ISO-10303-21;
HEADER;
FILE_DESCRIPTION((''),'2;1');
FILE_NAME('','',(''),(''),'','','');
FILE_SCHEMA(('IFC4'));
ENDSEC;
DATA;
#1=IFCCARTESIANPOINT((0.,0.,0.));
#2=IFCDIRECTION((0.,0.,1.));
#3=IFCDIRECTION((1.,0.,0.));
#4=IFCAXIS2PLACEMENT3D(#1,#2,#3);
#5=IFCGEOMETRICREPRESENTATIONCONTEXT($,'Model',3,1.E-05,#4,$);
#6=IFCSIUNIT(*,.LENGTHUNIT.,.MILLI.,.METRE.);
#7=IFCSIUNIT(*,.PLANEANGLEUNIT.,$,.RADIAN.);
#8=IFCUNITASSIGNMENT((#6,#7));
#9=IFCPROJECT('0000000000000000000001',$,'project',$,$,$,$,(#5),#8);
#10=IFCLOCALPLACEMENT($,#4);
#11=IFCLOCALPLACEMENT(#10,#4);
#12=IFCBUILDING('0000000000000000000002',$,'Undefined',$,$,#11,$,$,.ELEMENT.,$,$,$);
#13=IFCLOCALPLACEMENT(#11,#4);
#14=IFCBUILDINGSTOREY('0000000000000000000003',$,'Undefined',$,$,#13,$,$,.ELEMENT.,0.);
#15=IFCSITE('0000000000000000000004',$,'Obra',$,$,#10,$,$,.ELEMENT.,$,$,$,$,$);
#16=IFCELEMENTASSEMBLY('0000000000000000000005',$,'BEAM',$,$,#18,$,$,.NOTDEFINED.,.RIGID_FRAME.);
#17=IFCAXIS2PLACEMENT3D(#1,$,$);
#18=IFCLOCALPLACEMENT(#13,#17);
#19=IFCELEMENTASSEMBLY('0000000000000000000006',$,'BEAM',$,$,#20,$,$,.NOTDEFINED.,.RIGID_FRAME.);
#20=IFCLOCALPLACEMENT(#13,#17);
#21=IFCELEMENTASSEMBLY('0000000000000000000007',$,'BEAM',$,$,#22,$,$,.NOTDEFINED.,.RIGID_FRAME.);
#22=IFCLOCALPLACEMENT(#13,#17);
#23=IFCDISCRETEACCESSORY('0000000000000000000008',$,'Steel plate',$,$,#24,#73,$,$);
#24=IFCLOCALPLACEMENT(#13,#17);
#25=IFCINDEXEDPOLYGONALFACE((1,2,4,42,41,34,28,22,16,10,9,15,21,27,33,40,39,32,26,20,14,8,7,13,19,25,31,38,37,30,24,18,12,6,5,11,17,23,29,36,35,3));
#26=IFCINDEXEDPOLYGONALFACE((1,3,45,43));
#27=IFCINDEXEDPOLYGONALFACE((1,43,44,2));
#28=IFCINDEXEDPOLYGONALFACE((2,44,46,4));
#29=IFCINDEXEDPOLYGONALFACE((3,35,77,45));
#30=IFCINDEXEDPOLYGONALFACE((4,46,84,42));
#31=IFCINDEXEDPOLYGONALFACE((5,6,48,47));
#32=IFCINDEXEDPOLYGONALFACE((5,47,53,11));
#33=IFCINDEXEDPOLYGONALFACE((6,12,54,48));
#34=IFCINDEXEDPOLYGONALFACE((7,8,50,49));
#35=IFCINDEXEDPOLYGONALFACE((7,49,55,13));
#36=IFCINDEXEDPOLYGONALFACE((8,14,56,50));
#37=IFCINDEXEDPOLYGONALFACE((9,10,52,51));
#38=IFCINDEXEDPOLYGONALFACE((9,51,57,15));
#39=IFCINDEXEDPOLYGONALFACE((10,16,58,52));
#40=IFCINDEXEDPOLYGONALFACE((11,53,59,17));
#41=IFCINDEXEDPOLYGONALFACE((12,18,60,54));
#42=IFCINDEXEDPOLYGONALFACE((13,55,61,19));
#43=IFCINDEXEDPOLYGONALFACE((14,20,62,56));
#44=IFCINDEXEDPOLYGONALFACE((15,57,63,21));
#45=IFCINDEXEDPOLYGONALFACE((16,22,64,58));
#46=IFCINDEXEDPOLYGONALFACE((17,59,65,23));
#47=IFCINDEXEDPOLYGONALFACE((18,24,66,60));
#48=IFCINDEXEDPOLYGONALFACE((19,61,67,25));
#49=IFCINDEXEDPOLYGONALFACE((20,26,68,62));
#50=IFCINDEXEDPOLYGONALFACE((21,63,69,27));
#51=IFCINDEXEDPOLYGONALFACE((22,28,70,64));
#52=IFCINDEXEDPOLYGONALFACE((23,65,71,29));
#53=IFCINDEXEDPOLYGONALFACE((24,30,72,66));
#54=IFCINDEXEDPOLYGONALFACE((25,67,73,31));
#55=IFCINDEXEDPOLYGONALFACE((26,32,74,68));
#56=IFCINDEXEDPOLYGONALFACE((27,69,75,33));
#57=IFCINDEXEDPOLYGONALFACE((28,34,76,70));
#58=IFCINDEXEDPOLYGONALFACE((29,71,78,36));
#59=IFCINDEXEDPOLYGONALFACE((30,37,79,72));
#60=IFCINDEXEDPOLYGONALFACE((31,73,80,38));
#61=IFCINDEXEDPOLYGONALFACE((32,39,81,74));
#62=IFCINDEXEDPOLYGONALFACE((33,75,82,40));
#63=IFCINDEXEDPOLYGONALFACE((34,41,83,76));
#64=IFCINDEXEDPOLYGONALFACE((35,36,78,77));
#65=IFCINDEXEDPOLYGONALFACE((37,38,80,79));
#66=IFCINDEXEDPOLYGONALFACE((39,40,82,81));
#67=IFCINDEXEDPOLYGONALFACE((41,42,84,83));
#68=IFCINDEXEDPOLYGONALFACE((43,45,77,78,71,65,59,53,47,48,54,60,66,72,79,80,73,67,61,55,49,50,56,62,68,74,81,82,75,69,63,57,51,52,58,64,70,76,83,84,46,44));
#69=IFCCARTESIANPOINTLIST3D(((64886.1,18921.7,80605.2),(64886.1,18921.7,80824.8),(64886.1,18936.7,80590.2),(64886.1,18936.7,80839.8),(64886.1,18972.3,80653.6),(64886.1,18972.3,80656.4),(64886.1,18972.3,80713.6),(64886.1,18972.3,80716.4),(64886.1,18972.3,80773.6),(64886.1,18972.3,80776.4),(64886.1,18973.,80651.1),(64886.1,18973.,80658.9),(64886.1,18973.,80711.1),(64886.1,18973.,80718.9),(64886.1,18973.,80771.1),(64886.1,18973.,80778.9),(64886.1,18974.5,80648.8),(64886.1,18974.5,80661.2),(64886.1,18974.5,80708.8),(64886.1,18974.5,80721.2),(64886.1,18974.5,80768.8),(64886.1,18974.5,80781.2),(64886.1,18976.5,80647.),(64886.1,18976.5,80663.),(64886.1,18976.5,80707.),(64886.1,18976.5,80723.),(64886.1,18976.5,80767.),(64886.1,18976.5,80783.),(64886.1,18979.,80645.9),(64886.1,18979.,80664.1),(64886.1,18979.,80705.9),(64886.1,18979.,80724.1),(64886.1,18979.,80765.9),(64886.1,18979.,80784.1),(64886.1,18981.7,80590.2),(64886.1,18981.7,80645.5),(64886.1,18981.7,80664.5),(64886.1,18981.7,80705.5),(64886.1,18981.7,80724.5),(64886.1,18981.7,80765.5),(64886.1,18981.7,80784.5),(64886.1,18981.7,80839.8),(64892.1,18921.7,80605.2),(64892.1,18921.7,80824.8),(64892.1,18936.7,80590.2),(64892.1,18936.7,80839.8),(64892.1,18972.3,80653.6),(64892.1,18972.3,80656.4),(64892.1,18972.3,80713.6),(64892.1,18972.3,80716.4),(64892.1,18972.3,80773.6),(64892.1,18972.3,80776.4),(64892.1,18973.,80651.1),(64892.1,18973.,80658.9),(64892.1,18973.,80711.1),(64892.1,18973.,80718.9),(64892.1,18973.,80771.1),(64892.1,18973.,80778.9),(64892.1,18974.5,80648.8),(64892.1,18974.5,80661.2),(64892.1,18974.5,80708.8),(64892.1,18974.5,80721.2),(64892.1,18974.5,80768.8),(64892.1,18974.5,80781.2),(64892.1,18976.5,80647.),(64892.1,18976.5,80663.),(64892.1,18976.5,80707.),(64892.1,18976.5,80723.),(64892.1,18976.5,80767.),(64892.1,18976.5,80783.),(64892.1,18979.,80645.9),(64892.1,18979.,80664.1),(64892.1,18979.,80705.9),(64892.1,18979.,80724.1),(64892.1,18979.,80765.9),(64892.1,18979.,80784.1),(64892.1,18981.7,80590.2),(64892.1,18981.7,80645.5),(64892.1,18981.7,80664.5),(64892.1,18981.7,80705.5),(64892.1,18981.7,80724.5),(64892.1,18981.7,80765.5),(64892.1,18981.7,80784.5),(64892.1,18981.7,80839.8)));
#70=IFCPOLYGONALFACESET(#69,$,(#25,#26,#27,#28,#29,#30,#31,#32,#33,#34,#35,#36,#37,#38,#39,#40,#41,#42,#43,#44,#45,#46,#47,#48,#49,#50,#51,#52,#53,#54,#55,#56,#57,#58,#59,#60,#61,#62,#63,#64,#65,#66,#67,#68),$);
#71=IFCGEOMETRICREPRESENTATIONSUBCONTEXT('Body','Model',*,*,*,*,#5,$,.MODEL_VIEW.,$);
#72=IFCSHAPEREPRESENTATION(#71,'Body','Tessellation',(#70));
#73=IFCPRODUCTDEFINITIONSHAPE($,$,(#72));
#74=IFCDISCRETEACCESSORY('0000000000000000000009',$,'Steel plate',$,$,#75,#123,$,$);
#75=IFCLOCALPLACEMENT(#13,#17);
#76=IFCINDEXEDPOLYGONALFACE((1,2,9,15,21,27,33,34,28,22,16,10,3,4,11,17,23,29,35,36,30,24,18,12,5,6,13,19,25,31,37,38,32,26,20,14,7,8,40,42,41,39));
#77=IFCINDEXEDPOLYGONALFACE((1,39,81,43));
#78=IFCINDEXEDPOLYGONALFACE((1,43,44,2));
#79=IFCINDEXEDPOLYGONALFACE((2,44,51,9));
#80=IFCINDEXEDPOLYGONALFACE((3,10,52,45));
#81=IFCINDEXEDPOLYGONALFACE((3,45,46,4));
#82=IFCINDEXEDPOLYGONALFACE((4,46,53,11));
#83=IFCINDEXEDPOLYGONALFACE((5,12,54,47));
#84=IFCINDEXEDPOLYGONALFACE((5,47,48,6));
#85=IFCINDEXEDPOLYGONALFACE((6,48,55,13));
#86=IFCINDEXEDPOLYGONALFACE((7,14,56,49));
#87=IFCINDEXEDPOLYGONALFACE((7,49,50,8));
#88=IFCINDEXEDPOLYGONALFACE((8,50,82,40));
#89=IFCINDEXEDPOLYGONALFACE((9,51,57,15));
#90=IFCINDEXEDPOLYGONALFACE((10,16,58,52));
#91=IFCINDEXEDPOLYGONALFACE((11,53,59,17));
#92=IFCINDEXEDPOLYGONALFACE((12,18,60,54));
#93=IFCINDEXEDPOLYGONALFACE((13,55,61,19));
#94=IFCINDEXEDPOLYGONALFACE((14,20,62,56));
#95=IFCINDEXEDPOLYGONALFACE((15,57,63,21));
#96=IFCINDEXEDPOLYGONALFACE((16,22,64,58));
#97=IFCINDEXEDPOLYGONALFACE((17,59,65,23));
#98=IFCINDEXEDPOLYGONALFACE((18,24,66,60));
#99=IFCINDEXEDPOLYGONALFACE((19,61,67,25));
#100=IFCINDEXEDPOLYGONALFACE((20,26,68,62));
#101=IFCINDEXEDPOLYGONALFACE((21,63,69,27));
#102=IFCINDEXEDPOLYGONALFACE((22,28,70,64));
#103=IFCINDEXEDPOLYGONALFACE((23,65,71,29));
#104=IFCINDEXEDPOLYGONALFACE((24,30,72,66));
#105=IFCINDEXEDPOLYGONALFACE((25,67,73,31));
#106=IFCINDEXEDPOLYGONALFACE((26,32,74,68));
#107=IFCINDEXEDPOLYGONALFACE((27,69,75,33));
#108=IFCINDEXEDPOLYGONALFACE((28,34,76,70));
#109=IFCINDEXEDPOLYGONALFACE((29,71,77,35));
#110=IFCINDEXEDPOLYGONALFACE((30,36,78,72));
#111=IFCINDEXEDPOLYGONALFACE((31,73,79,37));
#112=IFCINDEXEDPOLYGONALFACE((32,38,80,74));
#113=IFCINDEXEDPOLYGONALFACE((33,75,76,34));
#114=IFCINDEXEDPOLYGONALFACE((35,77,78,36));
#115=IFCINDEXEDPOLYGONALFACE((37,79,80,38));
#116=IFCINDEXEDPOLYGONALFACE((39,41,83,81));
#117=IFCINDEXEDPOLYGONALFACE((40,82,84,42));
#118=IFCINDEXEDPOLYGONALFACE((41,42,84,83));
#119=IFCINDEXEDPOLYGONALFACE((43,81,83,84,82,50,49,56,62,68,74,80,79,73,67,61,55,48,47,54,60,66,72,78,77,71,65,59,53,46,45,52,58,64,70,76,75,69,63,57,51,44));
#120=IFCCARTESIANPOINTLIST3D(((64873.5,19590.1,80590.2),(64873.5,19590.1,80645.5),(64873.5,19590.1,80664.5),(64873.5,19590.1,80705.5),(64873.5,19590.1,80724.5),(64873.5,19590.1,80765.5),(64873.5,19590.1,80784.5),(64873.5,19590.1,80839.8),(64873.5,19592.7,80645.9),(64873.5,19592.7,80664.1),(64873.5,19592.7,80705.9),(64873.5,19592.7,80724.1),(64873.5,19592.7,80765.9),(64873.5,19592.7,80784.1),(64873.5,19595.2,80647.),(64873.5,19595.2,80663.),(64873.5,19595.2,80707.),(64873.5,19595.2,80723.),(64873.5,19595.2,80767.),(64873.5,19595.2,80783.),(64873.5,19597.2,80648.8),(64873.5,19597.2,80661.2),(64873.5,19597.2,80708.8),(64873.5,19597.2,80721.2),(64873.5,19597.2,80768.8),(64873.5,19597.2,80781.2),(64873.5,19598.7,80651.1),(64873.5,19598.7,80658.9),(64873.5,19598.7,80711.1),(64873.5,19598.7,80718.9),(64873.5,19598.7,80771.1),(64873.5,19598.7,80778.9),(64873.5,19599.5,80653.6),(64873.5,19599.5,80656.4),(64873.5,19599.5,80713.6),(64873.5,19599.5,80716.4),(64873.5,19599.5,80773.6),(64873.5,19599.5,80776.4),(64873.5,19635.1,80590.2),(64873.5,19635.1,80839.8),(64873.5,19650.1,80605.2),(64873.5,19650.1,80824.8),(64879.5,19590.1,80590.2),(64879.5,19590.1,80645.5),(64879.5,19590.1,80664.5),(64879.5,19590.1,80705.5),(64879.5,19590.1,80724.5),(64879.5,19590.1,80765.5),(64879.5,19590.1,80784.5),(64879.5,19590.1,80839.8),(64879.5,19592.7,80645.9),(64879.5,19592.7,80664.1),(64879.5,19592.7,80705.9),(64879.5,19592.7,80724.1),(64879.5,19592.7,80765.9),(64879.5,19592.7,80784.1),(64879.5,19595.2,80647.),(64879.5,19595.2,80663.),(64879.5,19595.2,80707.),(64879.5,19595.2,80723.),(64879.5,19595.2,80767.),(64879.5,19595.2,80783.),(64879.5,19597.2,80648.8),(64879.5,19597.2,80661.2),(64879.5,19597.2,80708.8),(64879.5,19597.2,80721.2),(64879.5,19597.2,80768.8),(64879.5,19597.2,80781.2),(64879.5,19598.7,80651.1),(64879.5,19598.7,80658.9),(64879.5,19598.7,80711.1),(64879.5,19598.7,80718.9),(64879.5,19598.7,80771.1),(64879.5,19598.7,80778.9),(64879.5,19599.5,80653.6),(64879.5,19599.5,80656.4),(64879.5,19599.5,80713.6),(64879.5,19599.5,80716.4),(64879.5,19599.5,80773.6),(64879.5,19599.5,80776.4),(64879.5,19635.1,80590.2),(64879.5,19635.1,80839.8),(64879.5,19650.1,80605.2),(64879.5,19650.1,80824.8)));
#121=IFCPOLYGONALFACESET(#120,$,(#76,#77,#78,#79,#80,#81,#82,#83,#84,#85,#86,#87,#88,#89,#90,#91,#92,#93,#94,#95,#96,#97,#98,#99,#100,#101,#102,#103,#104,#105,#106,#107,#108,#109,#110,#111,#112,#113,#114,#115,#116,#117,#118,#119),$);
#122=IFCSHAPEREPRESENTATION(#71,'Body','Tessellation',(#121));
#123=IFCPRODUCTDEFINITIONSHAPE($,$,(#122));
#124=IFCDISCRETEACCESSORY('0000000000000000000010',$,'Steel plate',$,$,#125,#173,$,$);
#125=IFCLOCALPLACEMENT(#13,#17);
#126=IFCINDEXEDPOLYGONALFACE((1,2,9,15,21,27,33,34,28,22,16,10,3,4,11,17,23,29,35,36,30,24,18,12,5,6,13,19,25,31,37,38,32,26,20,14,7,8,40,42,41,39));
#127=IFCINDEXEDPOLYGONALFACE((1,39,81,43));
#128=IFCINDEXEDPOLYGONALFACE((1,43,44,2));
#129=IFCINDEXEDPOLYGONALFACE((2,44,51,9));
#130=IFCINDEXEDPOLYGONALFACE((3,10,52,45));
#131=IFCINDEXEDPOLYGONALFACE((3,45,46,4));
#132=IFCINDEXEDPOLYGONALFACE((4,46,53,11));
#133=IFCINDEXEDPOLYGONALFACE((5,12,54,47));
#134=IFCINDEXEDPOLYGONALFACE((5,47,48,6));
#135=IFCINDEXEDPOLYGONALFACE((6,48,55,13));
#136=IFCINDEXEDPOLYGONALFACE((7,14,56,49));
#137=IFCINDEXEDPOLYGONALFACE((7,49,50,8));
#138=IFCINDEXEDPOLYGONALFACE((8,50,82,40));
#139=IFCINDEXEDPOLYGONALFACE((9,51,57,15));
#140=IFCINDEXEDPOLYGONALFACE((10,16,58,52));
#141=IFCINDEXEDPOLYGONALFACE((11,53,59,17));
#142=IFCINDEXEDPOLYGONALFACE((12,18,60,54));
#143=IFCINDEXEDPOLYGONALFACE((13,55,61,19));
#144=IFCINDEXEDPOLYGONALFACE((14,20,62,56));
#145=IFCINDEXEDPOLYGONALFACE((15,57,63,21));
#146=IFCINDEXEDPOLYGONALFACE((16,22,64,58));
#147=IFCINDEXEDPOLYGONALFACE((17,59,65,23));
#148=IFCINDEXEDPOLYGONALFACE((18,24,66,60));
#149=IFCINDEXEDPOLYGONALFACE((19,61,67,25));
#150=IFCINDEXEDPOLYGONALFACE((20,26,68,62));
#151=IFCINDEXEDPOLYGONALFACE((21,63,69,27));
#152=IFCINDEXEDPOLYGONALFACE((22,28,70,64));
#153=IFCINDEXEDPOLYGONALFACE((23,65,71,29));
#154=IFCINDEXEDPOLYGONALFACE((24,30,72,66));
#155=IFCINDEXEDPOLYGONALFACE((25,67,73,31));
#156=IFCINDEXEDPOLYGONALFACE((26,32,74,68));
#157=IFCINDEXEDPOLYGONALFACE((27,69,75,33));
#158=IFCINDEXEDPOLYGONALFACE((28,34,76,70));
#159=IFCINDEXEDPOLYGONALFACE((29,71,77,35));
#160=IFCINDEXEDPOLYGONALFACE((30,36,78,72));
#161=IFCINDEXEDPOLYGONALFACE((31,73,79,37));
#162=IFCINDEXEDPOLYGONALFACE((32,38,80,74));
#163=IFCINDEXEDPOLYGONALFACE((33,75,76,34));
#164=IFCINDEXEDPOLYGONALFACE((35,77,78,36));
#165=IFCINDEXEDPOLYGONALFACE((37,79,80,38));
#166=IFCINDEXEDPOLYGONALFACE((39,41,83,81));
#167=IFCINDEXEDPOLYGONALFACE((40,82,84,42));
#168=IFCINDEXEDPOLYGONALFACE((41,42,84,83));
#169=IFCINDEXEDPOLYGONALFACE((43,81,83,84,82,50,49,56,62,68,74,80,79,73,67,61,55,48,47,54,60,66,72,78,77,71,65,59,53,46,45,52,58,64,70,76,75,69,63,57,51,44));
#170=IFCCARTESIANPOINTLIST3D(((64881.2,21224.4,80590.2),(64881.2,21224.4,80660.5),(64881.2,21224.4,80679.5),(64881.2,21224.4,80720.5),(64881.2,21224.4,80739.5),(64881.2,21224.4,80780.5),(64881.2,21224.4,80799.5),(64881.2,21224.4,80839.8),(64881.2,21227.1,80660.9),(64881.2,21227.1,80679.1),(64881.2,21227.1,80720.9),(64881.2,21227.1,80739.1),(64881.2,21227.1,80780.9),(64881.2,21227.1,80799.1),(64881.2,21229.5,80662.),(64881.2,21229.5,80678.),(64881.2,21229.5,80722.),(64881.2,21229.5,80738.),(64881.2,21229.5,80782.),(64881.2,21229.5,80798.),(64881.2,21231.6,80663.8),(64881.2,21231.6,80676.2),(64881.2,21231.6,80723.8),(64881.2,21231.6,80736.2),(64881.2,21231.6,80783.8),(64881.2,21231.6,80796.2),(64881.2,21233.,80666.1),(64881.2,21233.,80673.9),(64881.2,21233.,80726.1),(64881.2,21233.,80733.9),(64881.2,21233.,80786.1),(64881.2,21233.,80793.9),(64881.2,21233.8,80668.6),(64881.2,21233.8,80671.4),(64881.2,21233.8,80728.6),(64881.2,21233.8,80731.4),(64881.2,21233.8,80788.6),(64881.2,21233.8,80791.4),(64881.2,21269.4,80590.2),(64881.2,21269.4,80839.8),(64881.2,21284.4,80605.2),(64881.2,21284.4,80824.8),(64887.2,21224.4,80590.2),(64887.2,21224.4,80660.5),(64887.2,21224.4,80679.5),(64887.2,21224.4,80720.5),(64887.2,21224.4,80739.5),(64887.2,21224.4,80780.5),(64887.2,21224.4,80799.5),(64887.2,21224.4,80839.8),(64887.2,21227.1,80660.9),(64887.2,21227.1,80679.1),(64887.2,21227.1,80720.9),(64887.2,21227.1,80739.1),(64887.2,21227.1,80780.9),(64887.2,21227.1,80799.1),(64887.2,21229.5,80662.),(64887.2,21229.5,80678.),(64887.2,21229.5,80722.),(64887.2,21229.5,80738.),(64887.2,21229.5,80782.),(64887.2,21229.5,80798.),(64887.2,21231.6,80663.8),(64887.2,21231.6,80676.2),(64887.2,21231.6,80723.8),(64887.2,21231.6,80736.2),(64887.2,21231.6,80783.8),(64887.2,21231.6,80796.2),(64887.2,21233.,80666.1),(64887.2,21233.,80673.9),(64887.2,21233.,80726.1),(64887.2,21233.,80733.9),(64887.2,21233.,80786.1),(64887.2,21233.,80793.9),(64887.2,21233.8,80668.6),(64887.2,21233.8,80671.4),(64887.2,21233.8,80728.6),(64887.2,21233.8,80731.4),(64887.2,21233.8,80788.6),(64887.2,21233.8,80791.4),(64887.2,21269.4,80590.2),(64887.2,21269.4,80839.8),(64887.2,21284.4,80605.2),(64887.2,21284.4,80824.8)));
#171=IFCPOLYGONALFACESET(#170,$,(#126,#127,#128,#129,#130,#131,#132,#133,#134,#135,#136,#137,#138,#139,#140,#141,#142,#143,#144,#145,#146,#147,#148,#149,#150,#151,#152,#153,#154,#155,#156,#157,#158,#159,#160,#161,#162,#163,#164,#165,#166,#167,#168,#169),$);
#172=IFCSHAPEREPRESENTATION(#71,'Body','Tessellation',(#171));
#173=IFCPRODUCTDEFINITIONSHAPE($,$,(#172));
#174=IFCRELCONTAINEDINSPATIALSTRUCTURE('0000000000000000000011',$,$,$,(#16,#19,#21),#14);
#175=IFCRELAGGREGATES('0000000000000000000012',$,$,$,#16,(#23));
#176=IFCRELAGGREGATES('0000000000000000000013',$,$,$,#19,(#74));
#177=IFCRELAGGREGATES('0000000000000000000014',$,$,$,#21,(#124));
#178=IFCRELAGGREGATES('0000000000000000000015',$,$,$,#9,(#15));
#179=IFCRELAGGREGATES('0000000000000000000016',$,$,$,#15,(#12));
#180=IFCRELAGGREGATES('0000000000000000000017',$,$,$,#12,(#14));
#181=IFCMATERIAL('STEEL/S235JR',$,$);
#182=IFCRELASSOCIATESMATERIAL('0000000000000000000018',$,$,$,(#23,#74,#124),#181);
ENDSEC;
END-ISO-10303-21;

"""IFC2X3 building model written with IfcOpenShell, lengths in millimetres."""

from ifc_helpers import new_model, si_unit, frame, origin_with_axes, origin_2d_with_axis, place, context, subcontext, project, spatial, polyline, circle, outline, extrude, source, transform, mapped, material, element, aggregate, save


model = new_model("IFC2X3")

# Units and contexts
model_context = context("Model", 3, precision=1e-05, world=origin_with_axes())
body_context = subcontext(model_context, "Body", "Model", "MODEL_VIEW")
ifc_project = project(units=[si_unit("LENGTHUNIT", "METRE", prefix="MILLI"), si_unit("PLANEANGLEUNIT", "RADIAN")], contexts=[model_context])

# Site, building, storey
site_placement = place(None, origin_with_axes())
site = spatial("IfcSite", under=ifc_project, at=site_placement, Name="Obra", CompositionType="ELEMENT")
building_placement = place(site_placement, origin_with_axes())
building = spatial("IfcBuilding", under=site, at=building_placement, Name="Undefined", CompositionType="ELEMENT")
storey_placement = place(building_placement, origin_with_axes())
storey = spatial("IfcBuildingStorey", under=building, at=storey_placement, Name="Undefined", CompositionType="ELEMENT", Elevation=0.0)

# Element assemblies
ifc_material = material(Name="STEEL/S235JR")
assembly_1_placement = place(storey_placement, origin_with_axes())
assembly_1 = element("IfcElementAssembly", 1, at=assembly_1_placement, inside=storey, Name="BEAM", AssemblyPlace="NOTDEFINED", PredefinedType="RIGID_FRAME")
assembly_2_placement = place(storey_placement, origin_with_axes())
assembly_2 = element("IfcElementAssembly", 2, at=assembly_2_placement, inside=storey, Name="BEAM", AssemblyPlace="NOTDEFINED", PredefinedType="RIGID_FRAME")
assembly_3_placement = place(storey_placement, origin_with_axes())
assembly_3 = element("IfcElementAssembly", 3, at=assembly_3_placement, inside=storey, Name="BEAM", AssemblyPlace="NOTDEFINED", PredefinedType="RIGID_FRAME")

# Discrete accessories, openings
discrete_accessory_1_placement = place(assembly_1_placement, frame((64889.1, 18981.7, 80590.2), z_axis=(-1.0, -0.000001, 0.0), x_axis=(0.000001, -1.0, 0.0)))
discrete_accessory_1 = element("IfcDiscreteAccessory", 4, at=discrete_accessory_1_placement, material=ifc_material, Name="Steel plate", context=body_context, shape_type="SweptSolid", body=[
    extrude(outline(polyline([(0.0, 0.0), (45.0, 0.0), (60.0, 15.0), (60.0, 234.6), (45.0, 249.6), (0.0, 249.6), (0.0, 0.0)])), frame((0.0, 0.0, -3.0), z_axis=(0.0, 0.0, 1.0), x_axis=(1.0, 0.0, 0.0)), (0.0, 0.0, 1.0), 6.0),
])
shared_shape_1 = source(origin_with_axes(), body_context, "Body", "SweptSolid", [
    extrude(circle(Radius=9.5, at=origin_2d_with_axis()), frame((0.0, -9.4, 0.0), z_axis=(0.0, 1.0, 0.0), x_axis=(1.0, 0.0, 0.0)), (0.0, 0.0, 1.0), 6.2),
])
opening_1_placement = place(assembly_1_placement, frame((64882.8, 18931.7, 80850.0), z_axis=(-0.000001, 1.0, 0.0), x_axis=(0.0, 0.0, -1.0)))
element("IfcOpeningElement", 5, at=opening_1_placement, cuts=discrete_accessory_1, ObjectType="Opening", context=body_context, shape_type="MappedRepresentation", body=[
    mapped(shared_shape_1, transform((75.0, 0.0, 50.0))),
    mapped(shared_shape_1, transform((135.0, 0.0, 50.0))),
    mapped(shared_shape_1, transform((195.0, 0.0, 50.0))),
])
aggregate(assembly_1, [discrete_accessory_1])
discrete_accessory_2_placement = place(assembly_2_placement, frame((64876.5, 19590.1, 80590.2), z_axis=(1.0, 0.000001, 0.0), x_axis=(-0.000001, 1.0, 0.0)))
discrete_accessory_2 = element("IfcDiscreteAccessory", 6, at=discrete_accessory_2_placement, material=ifc_material, Name="Steel plate", context=body_context, shape_type="SweptSolid", body=[
    extrude(outline(polyline([(0.0, 0.0), (45.0, 0.0), (60.0, 15.0), (60.0, 234.6), (45.0, 249.6), (0.0, 249.6), (0.0, 0.0)])), frame((0.0, 0.0, -3.0), z_axis=(0.0, 0.0, 1.0), x_axis=(1.0, 0.0, 0.0)), (0.0, 0.0, 1.0), 6.0),
])
opening_2_placement = place(assembly_2_placement, frame((64882.8, 19640.1, 80850.0), z_axis=(0.000001, -1.0, 0.0), x_axis=(0.0, 0.0, -1.0)))
element("IfcOpeningElement", 7, at=opening_2_placement, cuts=discrete_accessory_2, ObjectType="Opening", context=body_context, shape_type="MappedRepresentation", body=[
    mapped(shared_shape_1, transform((75.0, 0.0, 50.0))),
    mapped(shared_shape_1, transform((135.0, 0.0, 50.0))),
    mapped(shared_shape_1, transform((195.0, 0.0, 50.0))),
])
aggregate(assembly_2, [discrete_accessory_2])
discrete_accessory_3_placement = place(assembly_3_placement, frame((64884.2, 21224.4, 80590.2), z_axis=(1.0, 0.000001, 0.0), x_axis=(-0.000001, 1.0, 0.0)))
discrete_accessory_3 = element("IfcDiscreteAccessory", 8, at=discrete_accessory_3_placement, material=ifc_material, Name="Steel plate", context=body_context, shape_type="SweptSolid", body=[
    extrude(outline(polyline([(0.0, 0.0), (45.0, 0.0), (60.0, 15.0), (60.0, 234.6), (45.0, 249.6), (0.0, 249.6), (0.0, 0.0)])), frame((0.0, 0.0, -3.0), z_axis=(0.0, 0.0, 1.0), x_axis=(1.0, 0.0, 0.0)), (0.0, 0.0, 1.0), 6.0),
])
shared_shape_2 = source(origin_with_axes(), body_context, "Body", "SweptSolid", [
    extrude(circle(Radius=9.5, at=origin_2d_with_axis()), frame((0.0, -9.2, 0.0), z_axis=(0.0, 1.0, 0.0), x_axis=(1.0, 0.0, 0.0)), (0.0, 0.0, 1.0), 6.2),
])
opening_3_placement = place(assembly_3_placement, frame((64890.3, 21274.4, 80850.0), z_axis=(0.000001, -1.0, 0.0), x_axis=(0.0, 0.0, -1.0)))
element("IfcOpeningElement", 9, at=opening_3_placement, cuts=discrete_accessory_3, ObjectType="Opening", context=body_context, shape_type="MappedRepresentation", body=[
    mapped(shared_shape_2, transform((60.0, 0.0, 50.0))),
    mapped(shared_shape_2, transform((120.0, 0.0, 50.0))),
    mapped(shared_shape_2, transform((180.0, 0.0, 50.0))),
])
aggregate(assembly_3, [discrete_accessory_3])

save(model, "model.ifc")
